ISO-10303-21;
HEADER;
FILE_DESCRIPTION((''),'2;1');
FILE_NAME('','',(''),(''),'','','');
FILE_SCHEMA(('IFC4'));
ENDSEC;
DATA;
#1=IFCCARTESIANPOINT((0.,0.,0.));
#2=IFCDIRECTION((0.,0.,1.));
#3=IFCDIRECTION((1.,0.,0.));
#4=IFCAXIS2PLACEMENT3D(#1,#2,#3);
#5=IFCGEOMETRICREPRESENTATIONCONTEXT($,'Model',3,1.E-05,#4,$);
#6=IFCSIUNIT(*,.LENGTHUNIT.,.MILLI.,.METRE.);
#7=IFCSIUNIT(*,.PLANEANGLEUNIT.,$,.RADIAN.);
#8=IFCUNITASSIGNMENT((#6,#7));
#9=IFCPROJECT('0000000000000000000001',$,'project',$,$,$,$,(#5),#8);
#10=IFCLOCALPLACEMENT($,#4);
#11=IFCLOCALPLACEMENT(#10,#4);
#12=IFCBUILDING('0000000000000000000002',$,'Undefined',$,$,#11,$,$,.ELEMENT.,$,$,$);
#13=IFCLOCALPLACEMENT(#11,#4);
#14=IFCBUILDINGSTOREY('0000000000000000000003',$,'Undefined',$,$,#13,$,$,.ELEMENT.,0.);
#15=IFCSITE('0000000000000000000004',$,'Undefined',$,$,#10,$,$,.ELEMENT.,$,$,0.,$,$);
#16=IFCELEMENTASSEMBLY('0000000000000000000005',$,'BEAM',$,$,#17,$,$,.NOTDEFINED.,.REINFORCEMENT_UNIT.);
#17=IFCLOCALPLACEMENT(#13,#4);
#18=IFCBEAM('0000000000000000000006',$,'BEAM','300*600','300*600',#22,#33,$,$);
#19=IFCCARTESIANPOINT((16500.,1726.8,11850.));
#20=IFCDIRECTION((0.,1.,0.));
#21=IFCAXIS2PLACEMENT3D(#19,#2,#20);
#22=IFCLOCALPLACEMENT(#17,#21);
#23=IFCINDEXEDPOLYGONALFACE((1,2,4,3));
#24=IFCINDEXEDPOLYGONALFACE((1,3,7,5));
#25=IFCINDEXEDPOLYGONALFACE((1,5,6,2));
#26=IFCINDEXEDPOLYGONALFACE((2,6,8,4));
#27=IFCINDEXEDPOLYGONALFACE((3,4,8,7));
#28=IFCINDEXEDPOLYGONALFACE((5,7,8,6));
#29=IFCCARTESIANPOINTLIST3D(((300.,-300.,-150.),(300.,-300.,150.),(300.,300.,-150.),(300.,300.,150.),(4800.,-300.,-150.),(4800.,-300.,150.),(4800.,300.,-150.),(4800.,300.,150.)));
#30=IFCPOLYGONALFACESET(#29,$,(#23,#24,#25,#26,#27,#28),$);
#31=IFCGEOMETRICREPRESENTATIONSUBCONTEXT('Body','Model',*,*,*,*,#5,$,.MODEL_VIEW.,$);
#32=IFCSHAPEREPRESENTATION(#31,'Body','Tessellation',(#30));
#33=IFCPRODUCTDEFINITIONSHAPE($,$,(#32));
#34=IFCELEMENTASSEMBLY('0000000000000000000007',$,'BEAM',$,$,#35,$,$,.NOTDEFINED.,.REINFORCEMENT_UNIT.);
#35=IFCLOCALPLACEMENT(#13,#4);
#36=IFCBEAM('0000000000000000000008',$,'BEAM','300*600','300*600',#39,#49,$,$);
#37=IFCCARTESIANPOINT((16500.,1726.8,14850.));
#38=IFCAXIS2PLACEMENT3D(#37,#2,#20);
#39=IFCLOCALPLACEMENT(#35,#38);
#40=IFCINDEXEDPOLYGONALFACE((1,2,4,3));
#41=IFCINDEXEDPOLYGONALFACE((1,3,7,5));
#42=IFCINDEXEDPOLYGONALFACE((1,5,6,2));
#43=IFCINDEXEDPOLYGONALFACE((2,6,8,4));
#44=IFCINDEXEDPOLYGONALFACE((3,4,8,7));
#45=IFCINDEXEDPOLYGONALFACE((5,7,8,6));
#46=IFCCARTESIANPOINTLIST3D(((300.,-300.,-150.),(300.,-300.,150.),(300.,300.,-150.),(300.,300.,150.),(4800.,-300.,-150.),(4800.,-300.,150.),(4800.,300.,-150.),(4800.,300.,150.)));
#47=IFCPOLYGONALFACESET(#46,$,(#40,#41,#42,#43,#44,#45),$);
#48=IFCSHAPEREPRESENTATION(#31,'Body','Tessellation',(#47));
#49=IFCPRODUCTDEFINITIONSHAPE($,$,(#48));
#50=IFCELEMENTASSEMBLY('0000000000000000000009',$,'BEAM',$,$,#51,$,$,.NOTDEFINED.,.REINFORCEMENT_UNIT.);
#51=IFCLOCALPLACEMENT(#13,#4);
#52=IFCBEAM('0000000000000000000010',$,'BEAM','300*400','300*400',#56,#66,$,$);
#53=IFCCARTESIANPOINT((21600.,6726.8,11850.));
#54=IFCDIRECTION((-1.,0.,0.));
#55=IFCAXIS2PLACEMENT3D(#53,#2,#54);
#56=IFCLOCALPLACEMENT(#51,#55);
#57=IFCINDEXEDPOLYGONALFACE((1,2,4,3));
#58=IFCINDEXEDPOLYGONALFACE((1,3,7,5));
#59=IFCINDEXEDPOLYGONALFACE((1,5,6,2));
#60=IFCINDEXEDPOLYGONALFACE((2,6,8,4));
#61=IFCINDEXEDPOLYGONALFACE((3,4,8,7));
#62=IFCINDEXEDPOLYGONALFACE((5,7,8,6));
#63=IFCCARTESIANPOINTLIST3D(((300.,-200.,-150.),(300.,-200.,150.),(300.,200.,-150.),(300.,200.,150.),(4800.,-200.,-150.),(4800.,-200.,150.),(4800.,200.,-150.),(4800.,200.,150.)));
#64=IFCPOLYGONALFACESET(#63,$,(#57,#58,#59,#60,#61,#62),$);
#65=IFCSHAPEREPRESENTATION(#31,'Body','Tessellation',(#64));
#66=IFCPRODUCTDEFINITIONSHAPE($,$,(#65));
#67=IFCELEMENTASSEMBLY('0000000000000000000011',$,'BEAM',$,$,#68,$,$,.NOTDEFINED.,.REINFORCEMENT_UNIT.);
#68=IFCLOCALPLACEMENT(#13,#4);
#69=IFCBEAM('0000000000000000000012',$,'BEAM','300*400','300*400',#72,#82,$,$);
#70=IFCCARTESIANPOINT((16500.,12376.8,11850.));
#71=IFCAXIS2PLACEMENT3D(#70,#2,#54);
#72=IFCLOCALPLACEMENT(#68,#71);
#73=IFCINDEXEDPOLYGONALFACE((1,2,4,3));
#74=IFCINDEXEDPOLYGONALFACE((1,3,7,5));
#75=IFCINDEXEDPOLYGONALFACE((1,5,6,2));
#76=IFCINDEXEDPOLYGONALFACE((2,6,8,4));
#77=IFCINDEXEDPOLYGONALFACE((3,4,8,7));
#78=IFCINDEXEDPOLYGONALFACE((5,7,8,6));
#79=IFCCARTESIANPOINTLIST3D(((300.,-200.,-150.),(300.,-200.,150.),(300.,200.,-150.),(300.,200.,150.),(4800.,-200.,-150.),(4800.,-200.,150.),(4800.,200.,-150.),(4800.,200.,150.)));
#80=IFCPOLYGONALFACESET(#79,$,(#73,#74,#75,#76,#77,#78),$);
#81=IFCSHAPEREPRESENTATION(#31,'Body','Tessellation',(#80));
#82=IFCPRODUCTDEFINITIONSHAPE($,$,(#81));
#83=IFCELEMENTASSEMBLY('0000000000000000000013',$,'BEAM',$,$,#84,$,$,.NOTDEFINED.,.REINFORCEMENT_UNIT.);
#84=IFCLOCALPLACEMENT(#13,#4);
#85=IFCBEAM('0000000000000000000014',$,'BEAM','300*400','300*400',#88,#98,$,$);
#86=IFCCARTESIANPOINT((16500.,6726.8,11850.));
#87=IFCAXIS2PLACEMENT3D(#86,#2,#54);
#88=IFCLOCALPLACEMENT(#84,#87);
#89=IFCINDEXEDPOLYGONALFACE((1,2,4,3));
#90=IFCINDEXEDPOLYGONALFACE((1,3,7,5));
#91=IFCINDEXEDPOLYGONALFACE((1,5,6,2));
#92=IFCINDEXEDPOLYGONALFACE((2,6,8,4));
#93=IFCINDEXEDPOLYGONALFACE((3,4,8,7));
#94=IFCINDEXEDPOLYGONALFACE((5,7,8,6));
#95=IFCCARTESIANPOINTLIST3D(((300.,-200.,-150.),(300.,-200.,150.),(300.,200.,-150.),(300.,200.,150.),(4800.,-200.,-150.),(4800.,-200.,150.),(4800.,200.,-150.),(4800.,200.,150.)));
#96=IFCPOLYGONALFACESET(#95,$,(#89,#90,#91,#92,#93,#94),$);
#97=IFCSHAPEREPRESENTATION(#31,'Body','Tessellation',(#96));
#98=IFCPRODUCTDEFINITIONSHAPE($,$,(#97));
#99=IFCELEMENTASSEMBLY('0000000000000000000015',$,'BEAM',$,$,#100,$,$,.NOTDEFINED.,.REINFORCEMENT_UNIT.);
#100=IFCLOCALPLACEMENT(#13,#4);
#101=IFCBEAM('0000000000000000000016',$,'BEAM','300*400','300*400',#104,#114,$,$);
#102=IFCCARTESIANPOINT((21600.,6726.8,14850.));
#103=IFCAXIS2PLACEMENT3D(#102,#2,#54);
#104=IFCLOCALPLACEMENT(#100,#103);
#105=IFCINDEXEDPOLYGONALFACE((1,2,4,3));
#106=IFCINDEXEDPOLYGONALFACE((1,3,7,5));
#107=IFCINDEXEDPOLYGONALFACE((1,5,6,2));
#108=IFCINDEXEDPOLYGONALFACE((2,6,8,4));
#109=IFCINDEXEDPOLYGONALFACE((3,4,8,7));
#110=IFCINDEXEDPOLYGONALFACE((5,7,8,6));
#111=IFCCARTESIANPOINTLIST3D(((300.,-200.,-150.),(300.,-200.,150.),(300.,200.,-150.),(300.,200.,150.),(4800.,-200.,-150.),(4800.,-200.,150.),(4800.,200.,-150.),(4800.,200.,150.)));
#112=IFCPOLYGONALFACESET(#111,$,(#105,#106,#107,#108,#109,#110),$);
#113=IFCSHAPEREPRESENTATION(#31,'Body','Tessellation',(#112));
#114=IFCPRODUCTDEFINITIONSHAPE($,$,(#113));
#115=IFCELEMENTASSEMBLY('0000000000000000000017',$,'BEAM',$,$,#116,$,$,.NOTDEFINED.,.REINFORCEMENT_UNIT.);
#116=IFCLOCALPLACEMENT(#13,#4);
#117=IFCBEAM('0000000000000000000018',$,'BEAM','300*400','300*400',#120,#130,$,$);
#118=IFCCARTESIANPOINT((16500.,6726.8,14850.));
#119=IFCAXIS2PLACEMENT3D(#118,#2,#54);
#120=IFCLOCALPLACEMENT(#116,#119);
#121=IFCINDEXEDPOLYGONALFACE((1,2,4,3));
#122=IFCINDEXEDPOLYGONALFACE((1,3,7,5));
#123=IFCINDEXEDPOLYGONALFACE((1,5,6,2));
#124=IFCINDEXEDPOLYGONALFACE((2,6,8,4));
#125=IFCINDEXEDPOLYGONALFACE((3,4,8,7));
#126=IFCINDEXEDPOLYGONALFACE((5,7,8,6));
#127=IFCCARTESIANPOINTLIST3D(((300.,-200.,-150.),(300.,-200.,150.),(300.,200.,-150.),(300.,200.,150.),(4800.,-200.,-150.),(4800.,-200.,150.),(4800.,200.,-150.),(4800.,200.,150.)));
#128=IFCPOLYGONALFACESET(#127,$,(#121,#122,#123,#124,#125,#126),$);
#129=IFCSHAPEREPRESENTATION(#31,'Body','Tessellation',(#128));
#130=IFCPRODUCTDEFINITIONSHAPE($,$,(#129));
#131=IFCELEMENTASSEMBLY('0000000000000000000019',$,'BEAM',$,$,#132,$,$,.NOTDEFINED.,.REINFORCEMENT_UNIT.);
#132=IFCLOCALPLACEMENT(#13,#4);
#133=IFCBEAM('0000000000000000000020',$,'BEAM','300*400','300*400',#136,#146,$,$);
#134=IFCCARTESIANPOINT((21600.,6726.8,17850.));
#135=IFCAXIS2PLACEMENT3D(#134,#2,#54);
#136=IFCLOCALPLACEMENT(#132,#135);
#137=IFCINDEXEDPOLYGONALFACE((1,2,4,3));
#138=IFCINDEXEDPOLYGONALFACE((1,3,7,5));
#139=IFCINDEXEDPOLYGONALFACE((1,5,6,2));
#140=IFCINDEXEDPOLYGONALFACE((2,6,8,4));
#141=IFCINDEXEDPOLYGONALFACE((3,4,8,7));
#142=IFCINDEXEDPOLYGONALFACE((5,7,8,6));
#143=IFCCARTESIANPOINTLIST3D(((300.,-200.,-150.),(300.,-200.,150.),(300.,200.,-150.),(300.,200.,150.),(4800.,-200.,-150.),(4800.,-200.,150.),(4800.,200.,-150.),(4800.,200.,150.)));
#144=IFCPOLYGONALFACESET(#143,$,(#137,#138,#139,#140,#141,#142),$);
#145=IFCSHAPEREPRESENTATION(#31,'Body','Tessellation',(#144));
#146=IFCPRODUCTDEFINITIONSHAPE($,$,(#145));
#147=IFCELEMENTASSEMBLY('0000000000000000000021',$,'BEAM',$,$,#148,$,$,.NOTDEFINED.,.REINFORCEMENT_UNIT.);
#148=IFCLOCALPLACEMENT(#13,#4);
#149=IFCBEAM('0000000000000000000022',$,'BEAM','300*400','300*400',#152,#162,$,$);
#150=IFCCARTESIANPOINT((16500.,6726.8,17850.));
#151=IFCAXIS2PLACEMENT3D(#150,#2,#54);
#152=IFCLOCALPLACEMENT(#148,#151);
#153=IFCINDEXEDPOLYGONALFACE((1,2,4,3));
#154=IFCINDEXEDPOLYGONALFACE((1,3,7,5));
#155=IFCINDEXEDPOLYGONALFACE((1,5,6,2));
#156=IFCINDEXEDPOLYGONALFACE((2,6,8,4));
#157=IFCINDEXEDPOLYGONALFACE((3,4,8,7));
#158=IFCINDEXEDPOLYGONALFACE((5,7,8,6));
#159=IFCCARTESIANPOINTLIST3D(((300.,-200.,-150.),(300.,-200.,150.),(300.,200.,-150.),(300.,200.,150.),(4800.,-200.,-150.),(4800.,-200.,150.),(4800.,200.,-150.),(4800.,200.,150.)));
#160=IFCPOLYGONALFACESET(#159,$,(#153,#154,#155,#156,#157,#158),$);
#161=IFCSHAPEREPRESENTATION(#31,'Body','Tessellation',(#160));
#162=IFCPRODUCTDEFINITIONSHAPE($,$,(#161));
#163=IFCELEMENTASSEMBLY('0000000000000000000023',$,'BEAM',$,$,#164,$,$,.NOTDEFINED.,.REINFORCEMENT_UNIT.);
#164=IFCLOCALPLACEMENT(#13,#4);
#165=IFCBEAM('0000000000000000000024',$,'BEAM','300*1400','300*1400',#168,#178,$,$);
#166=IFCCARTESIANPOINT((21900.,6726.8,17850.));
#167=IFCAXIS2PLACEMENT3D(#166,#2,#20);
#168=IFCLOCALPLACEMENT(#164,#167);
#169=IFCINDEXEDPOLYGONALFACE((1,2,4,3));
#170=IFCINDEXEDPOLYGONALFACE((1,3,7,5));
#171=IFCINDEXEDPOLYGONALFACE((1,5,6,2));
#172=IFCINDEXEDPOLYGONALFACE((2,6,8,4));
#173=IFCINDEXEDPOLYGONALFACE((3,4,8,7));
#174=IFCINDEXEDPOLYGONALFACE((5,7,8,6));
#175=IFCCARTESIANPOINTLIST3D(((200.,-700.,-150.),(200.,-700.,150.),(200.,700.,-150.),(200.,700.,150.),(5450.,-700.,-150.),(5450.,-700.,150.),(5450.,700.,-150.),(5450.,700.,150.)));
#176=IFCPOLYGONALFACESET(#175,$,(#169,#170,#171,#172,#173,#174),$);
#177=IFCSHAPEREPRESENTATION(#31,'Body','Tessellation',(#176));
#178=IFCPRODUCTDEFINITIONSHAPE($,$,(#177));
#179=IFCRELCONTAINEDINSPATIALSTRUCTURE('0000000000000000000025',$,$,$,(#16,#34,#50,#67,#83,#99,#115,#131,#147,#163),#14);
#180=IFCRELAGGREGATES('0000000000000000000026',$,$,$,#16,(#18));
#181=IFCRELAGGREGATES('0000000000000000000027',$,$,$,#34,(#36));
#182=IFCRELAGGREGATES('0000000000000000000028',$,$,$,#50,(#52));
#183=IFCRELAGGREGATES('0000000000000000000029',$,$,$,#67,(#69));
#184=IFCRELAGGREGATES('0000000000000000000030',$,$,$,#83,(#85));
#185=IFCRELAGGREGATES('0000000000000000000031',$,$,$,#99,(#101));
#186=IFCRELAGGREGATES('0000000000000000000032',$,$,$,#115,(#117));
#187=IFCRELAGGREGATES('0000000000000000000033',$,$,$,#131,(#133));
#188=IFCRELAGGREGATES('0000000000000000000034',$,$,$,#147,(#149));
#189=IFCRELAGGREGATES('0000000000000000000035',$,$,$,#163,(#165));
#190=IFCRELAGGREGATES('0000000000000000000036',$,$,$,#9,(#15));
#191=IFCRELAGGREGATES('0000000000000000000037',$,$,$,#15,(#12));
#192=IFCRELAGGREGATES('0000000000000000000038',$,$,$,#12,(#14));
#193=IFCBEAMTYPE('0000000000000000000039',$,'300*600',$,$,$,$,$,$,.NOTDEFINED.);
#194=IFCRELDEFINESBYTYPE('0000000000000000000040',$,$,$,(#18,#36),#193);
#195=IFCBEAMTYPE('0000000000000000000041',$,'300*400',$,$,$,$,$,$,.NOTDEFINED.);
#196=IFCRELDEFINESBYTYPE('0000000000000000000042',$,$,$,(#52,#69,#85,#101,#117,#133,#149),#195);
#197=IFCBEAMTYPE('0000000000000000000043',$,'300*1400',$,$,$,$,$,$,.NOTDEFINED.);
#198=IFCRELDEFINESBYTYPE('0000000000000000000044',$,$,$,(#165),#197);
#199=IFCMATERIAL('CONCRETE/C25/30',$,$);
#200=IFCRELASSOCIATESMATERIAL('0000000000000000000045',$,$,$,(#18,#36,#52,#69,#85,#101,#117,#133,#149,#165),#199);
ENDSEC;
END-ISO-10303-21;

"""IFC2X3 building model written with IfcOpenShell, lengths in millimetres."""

from ifc_helpers import new_model, si_unit, frame, origin_with_axes, origin_2d_with_axis, place, context, subcontext, project, spatial, rectangle, extrude, material, type_object, element, aggregate, save


model = new_model("IFC2X3")

# Units and contexts
model_context = context("Model", 3, precision=1e-05, world=origin_with_axes())
body_context = subcontext(model_context, "Body", "Model", "MODEL_VIEW")
ifc_project = project(units=[si_unit("LENGTHUNIT", "METRE", prefix="MILLI"), si_unit("PLANEANGLEUNIT", "RADIAN")], contexts=[model_context])

# Site, building, storey
site_placement = place(None, origin_with_axes())
site = spatial("IfcSite", under=ifc_project, at=site_placement, Name="Undefined", CompositionType="ELEMENT", RefElevation=0.0)
building_placement = place(site_placement, origin_with_axes())
building = spatial("IfcBuilding", under=site, at=building_placement, Name="Undefined", CompositionType="ELEMENT")
storey_placement = place(building_placement, origin_with_axes())
storey = spatial("IfcBuildingStorey", under=building, at=storey_placement, Name="Undefined", CompositionType="ELEMENT", Elevation=0.0)

# Shared definitions
ifc_material = material(Name="CONCRETE/C25/30")

# Element assemblies, beams
assembly_1_placement = place(storey_placement, origin_with_axes())
assembly_1 = element("IfcElementAssembly", 1, at=assembly_1_placement, inside=storey, Name="BEAM", AssemblyPlace="NOTDEFINED", PredefinedType="REINFORCEMENT_UNIT")
beam_type_1 = type_object("IfcBeamType", Name="300*600", PredefinedType="NOTDEFINED")
beam_1_placement = place(assembly_1_placement, frame((16500.0, 1726.8, 11850.0), z_axis=(0.0, 0.0, 1.0), x_axis=(0.0, 1.0, 0.0)))
beam_1 = element("IfcBeam", 2, at=beam_1_placement, type_object=beam_type_1, material=ifc_material, Name="BEAM", Description="300*600", ObjectType="300*600", context=body_context, shape_type="SweptSolid", body=[
    extrude(rectangle(XDim=600.0, YDim=300.0, at=origin_2d_with_axis()), frame((4800.0, 0.0, 0.0), z_axis=(-1.0, 0.0, 0.0), x_axis=(0.0, -1.0, 0.0)), (0.0, 0.0, 1.0), 4500.0),
])
aggregate(assembly_1, [beam_1])
assembly_2_placement = place(storey_placement, origin_with_axes())
assembly_2 = element("IfcElementAssembly", 3, at=assembly_2_placement, inside=storey, Name="BEAM", AssemblyPlace="NOTDEFINED", PredefinedType="REINFORCEMENT_UNIT")
beam_2_placement = place(assembly_2_placement, frame((16500.0, 1726.8, 14850.0), z_axis=(0.0, 0.0, 1.0), x_axis=(0.0, 1.0, 0.0)))
beam_2 = element("IfcBeam", 4, at=beam_2_placement, type_object=beam_type_1, material=ifc_material, Name="BEAM", Description="300*600", ObjectType="300*600", context=body_context, shape_type="SweptSolid", body=[
    extrude(rectangle(XDim=600.0, YDim=300.0, at=origin_2d_with_axis()), frame((4800.0, 0.0, 0.0), z_axis=(-1.0, 0.0, 0.0), x_axis=(0.0, -1.0, 0.0)), (0.0, 0.0, 1.0), 4500.0),
])
aggregate(assembly_2, [beam_2])
assembly_3_placement = place(storey_placement, origin_with_axes())
assembly_3 = element("IfcElementAssembly", 5, at=assembly_3_placement, inside=storey, Name="BEAM", AssemblyPlace="NOTDEFINED", PredefinedType="REINFORCEMENT_UNIT")
beam_type_2 = type_object("IfcBeamType", Name="300*400", PredefinedType="NOTDEFINED")
beam_3_placement = place(assembly_3_placement, frame((21600.0, 6726.8, 11850.0), z_axis=(0.0, 0.0, 1.0), x_axis=(-1.0, 0.0, 0.0)))
beam_3 = element("IfcBeam", 6, at=beam_3_placement, type_object=beam_type_2, material=ifc_material, Name="BEAM", Description="300*400", ObjectType="300*400", context=body_context, shape_type="SweptSolid", body=[
    extrude(rectangle(XDim=400.0, YDim=300.0, at=origin_2d_with_axis()), frame((4800.0, 0.0, 0.0), z_axis=(-1.0, 0.0, 0.0), x_axis=(0.0, -1.0, 0.0)), (0.0, 0.0, 1.0), 4500.0),
])
aggregate(assembly_3, [beam_3])
assembly_4_placement = place(storey_placement, origin_with_axes())
assembly_4 = element("IfcElementAssembly", 7, at=assembly_4_placement, inside=storey, Name="BEAM", AssemblyPlace="NOTDEFINED", PredefinedType="REINFORCEMENT_UNIT")
beam_4_placement = place(assembly_4_placement, frame((16500.0, 12376.8, 11850.0), z_axis=(0.0, 0.0, 1.0), x_axis=(-1.0, 0.0, 0.0)))
beam_4 = element("IfcBeam", 8, at=beam_4_placement, type_object=beam_type_2, material=ifc_material, Name="BEAM", Description="300*400", ObjectType="300*400", context=body_context, shape_type="SweptSolid", body=[
    extrude(rectangle(XDim=400.0, YDim=300.0, at=origin_2d_with_axis()), frame((4800.0, 0.0, 0.0), z_axis=(-1.0, 0.0, 0.0), x_axis=(0.0, -1.0, 0.0)), (0.0, 0.0, 1.0), 4500.0),
])
aggregate(assembly_4, [beam_4])
assembly_5_placement = place(storey_placement, origin_with_axes())
assembly_5 = element("IfcElementAssembly", 9, at=assembly_5_placement, inside=storey, Name="BEAM", AssemblyPlace="NOTDEFINED", PredefinedType="REINFORCEMENT_UNIT")
beam_5_placement = place(assembly_5_placement, frame((16500.0, 6726.8, 11850.0), z_axis=(0.0, 0.0, 1.0), x_axis=(-1.0, 0.0, 0.0)))
beam_5 = element("IfcBeam", 10, at=beam_5_placement, type_object=beam_type_2, material=ifc_material, Name="BEAM", Description="300*400", ObjectType="300*400", context=body_context, shape_type="SweptSolid", body=[
    extrude(rectangle(XDim=400.0, YDim=300.0, at=origin_2d_with_axis()), frame((4800.0, 0.0, 0.0), z_axis=(-1.0, 0.0, 0.0), x_axis=(0.0, -1.0, 0.0)), (0.0, 0.0, 1.0), 4500.0),
])
aggregate(assembly_5, [beam_5])
assembly_6_placement = place(storey_placement, origin_with_axes())
assembly_6 = element("IfcElementAssembly", 11, at=assembly_6_placement, inside=storey, Name="BEAM", AssemblyPlace="NOTDEFINED", PredefinedType="REINFORCEMENT_UNIT")
beam_6_placement = place(assembly_6_placement, frame((21600.0, 6726.8, 14850.0), z_axis=(0.0, 0.0, 1.0), x_axis=(-1.0, 0.0, 0.0)))
beam_6 = element("IfcBeam", 12, at=beam_6_placement, type_object=beam_type_2, material=ifc_material, Name="BEAM", Description="300*400", ObjectType="300*400", context=body_context, shape_type="SweptSolid", body=[
    extrude(rectangle(XDim=400.0, YDim=300.0, at=origin_2d_with_axis()), frame((4800.0, 0.0, 0.0), z_axis=(-1.0, 0.0, 0.0), x_axis=(0.0, -1.0, 0.0)), (0.0, 0.0, 1.0), 4500.0),
])
aggregate(assembly_6, [beam_6])
assembly_7_placement = place(storey_placement, origin_with_axes())
assembly_7 = element("IfcElementAssembly", 13, at=assembly_7_placement, inside=storey, Name="BEAM", AssemblyPlace="NOTDEFINED", PredefinedType="REINFORCEMENT_UNIT")
beam_7_placement = place(assembly_7_placement, frame((16500.0, 6726.8, 14850.0), z_axis=(0.0, 0.0, 1.0), x_axis=(-1.0, 0.0, 0.0)))
beam_7 = element("IfcBeam", 14, at=beam_7_placement, type_object=beam_type_2, material=ifc_material, Name="BEAM", Description="300*400", ObjectType="300*400", context=body_context, shape_type="SweptSolid", body=[
    extrude(rectangle(XDim=400.0, YDim=300.0, at=origin_2d_with_axis()), frame((4800.0, 0.0, 0.0), z_axis=(-1.0, 0.0, 0.0), x_axis=(0.0, -1.0, 0.0)), (0.0, 0.0, 1.0), 4500.0),
])
aggregate(assembly_7, [beam_7])
assembly_8_placement = place(storey_placement, origin_with_axes())
assembly_8 = element("IfcElementAssembly", 15, at=assembly_8_placement, inside=storey, Name="BEAM", AssemblyPlace="NOTDEFINED", PredefinedType="REINFORCEMENT_UNIT")
beam_8_placement = place(assembly_8_placement, frame((21600.0, 6726.8, 17850.0), z_axis=(0.0, 0.0, 1.0), x_axis=(-1.0, 0.0, 0.0)))
beam_8 = element("IfcBeam", 16, at=beam_8_placement, type_object=beam_type_2, material=ifc_material, Name="BEAM", Description="300*400", ObjectType="300*400", context=body_context, shape_type="SweptSolid", body=[
    extrude(rectangle(XDim=400.0, YDim=300.0, at=origin_2d_with_axis()), frame((4800.0, 0.0, 0.0), z_axis=(-1.0, 0.0, 0.0), x_axis=(0.0, -1.0, 0.0)), (0.0, 0.0, 1.0), 4500.0),
])
aggregate(assembly_8, [beam_8])
assembly_9_placement = place(storey_placement, origin_with_axes())
assembly_9 = element("IfcElementAssembly", 17, at=assembly_9_placement, inside=storey, Name="BEAM", AssemblyPlace="NOTDEFINED", PredefinedType="REINFORCEMENT_UNIT")
beam_9_placement = place(assembly_9_placement, frame((16500.0, 6726.8, 17850.0), z_axis=(0.0, 0.0, 1.0), x_axis=(-1.0, 0.0, 0.0)))
beam_9 = element("IfcBeam", 18, at=beam_9_placement, type_object=beam_type_2, material=ifc_material, Name="BEAM", Description="300*400", ObjectType="300*400", context=body_context, shape_type="SweptSolid", body=[
    extrude(rectangle(XDim=400.0, YDim=300.0, at=origin_2d_with_axis()), frame((4800.0, 0.0, 0.0), z_axis=(-1.0, 0.0, 0.0), x_axis=(0.0, -1.0, 0.0)), (0.0, 0.0, 1.0), 4500.0),
])
aggregate(assembly_9, [beam_9])
assembly_10_placement = place(storey_placement, origin_with_axes())
assembly_10 = element("IfcElementAssembly", 19, at=assembly_10_placement, inside=storey, Name="BEAM", AssemblyPlace="NOTDEFINED", PredefinedType="REINFORCEMENT_UNIT")
beam_type_3 = type_object("IfcBeamType", Name="300*1400", PredefinedType="NOTDEFINED")
beam_10_placement = place(assembly_10_placement, frame((21900.0, 6726.8, 17850.0), z_axis=(0.0, 0.0, 1.0), x_axis=(0.0, 1.0, 0.0)))
beam_10 = element("IfcBeam", 20, at=beam_10_placement, type_object=beam_type_3, material=ifc_material, Name="BEAM", Description="300*1400", ObjectType="300*1400", context=body_context, shape_type="SweptSolid", body=[
    extrude(rectangle(XDim=1400.0, YDim=300.0, at=origin_2d_with_axis()), frame((5450.0, 0.0, 0.0), z_axis=(-1.0, 0.0, 0.0), x_axis=(0.0, -1.0, 0.0)), (0.0, 0.0, 1.0), 5250.0),
])
aggregate(assembly_10, [beam_10])

save(model, "model.ifc")
